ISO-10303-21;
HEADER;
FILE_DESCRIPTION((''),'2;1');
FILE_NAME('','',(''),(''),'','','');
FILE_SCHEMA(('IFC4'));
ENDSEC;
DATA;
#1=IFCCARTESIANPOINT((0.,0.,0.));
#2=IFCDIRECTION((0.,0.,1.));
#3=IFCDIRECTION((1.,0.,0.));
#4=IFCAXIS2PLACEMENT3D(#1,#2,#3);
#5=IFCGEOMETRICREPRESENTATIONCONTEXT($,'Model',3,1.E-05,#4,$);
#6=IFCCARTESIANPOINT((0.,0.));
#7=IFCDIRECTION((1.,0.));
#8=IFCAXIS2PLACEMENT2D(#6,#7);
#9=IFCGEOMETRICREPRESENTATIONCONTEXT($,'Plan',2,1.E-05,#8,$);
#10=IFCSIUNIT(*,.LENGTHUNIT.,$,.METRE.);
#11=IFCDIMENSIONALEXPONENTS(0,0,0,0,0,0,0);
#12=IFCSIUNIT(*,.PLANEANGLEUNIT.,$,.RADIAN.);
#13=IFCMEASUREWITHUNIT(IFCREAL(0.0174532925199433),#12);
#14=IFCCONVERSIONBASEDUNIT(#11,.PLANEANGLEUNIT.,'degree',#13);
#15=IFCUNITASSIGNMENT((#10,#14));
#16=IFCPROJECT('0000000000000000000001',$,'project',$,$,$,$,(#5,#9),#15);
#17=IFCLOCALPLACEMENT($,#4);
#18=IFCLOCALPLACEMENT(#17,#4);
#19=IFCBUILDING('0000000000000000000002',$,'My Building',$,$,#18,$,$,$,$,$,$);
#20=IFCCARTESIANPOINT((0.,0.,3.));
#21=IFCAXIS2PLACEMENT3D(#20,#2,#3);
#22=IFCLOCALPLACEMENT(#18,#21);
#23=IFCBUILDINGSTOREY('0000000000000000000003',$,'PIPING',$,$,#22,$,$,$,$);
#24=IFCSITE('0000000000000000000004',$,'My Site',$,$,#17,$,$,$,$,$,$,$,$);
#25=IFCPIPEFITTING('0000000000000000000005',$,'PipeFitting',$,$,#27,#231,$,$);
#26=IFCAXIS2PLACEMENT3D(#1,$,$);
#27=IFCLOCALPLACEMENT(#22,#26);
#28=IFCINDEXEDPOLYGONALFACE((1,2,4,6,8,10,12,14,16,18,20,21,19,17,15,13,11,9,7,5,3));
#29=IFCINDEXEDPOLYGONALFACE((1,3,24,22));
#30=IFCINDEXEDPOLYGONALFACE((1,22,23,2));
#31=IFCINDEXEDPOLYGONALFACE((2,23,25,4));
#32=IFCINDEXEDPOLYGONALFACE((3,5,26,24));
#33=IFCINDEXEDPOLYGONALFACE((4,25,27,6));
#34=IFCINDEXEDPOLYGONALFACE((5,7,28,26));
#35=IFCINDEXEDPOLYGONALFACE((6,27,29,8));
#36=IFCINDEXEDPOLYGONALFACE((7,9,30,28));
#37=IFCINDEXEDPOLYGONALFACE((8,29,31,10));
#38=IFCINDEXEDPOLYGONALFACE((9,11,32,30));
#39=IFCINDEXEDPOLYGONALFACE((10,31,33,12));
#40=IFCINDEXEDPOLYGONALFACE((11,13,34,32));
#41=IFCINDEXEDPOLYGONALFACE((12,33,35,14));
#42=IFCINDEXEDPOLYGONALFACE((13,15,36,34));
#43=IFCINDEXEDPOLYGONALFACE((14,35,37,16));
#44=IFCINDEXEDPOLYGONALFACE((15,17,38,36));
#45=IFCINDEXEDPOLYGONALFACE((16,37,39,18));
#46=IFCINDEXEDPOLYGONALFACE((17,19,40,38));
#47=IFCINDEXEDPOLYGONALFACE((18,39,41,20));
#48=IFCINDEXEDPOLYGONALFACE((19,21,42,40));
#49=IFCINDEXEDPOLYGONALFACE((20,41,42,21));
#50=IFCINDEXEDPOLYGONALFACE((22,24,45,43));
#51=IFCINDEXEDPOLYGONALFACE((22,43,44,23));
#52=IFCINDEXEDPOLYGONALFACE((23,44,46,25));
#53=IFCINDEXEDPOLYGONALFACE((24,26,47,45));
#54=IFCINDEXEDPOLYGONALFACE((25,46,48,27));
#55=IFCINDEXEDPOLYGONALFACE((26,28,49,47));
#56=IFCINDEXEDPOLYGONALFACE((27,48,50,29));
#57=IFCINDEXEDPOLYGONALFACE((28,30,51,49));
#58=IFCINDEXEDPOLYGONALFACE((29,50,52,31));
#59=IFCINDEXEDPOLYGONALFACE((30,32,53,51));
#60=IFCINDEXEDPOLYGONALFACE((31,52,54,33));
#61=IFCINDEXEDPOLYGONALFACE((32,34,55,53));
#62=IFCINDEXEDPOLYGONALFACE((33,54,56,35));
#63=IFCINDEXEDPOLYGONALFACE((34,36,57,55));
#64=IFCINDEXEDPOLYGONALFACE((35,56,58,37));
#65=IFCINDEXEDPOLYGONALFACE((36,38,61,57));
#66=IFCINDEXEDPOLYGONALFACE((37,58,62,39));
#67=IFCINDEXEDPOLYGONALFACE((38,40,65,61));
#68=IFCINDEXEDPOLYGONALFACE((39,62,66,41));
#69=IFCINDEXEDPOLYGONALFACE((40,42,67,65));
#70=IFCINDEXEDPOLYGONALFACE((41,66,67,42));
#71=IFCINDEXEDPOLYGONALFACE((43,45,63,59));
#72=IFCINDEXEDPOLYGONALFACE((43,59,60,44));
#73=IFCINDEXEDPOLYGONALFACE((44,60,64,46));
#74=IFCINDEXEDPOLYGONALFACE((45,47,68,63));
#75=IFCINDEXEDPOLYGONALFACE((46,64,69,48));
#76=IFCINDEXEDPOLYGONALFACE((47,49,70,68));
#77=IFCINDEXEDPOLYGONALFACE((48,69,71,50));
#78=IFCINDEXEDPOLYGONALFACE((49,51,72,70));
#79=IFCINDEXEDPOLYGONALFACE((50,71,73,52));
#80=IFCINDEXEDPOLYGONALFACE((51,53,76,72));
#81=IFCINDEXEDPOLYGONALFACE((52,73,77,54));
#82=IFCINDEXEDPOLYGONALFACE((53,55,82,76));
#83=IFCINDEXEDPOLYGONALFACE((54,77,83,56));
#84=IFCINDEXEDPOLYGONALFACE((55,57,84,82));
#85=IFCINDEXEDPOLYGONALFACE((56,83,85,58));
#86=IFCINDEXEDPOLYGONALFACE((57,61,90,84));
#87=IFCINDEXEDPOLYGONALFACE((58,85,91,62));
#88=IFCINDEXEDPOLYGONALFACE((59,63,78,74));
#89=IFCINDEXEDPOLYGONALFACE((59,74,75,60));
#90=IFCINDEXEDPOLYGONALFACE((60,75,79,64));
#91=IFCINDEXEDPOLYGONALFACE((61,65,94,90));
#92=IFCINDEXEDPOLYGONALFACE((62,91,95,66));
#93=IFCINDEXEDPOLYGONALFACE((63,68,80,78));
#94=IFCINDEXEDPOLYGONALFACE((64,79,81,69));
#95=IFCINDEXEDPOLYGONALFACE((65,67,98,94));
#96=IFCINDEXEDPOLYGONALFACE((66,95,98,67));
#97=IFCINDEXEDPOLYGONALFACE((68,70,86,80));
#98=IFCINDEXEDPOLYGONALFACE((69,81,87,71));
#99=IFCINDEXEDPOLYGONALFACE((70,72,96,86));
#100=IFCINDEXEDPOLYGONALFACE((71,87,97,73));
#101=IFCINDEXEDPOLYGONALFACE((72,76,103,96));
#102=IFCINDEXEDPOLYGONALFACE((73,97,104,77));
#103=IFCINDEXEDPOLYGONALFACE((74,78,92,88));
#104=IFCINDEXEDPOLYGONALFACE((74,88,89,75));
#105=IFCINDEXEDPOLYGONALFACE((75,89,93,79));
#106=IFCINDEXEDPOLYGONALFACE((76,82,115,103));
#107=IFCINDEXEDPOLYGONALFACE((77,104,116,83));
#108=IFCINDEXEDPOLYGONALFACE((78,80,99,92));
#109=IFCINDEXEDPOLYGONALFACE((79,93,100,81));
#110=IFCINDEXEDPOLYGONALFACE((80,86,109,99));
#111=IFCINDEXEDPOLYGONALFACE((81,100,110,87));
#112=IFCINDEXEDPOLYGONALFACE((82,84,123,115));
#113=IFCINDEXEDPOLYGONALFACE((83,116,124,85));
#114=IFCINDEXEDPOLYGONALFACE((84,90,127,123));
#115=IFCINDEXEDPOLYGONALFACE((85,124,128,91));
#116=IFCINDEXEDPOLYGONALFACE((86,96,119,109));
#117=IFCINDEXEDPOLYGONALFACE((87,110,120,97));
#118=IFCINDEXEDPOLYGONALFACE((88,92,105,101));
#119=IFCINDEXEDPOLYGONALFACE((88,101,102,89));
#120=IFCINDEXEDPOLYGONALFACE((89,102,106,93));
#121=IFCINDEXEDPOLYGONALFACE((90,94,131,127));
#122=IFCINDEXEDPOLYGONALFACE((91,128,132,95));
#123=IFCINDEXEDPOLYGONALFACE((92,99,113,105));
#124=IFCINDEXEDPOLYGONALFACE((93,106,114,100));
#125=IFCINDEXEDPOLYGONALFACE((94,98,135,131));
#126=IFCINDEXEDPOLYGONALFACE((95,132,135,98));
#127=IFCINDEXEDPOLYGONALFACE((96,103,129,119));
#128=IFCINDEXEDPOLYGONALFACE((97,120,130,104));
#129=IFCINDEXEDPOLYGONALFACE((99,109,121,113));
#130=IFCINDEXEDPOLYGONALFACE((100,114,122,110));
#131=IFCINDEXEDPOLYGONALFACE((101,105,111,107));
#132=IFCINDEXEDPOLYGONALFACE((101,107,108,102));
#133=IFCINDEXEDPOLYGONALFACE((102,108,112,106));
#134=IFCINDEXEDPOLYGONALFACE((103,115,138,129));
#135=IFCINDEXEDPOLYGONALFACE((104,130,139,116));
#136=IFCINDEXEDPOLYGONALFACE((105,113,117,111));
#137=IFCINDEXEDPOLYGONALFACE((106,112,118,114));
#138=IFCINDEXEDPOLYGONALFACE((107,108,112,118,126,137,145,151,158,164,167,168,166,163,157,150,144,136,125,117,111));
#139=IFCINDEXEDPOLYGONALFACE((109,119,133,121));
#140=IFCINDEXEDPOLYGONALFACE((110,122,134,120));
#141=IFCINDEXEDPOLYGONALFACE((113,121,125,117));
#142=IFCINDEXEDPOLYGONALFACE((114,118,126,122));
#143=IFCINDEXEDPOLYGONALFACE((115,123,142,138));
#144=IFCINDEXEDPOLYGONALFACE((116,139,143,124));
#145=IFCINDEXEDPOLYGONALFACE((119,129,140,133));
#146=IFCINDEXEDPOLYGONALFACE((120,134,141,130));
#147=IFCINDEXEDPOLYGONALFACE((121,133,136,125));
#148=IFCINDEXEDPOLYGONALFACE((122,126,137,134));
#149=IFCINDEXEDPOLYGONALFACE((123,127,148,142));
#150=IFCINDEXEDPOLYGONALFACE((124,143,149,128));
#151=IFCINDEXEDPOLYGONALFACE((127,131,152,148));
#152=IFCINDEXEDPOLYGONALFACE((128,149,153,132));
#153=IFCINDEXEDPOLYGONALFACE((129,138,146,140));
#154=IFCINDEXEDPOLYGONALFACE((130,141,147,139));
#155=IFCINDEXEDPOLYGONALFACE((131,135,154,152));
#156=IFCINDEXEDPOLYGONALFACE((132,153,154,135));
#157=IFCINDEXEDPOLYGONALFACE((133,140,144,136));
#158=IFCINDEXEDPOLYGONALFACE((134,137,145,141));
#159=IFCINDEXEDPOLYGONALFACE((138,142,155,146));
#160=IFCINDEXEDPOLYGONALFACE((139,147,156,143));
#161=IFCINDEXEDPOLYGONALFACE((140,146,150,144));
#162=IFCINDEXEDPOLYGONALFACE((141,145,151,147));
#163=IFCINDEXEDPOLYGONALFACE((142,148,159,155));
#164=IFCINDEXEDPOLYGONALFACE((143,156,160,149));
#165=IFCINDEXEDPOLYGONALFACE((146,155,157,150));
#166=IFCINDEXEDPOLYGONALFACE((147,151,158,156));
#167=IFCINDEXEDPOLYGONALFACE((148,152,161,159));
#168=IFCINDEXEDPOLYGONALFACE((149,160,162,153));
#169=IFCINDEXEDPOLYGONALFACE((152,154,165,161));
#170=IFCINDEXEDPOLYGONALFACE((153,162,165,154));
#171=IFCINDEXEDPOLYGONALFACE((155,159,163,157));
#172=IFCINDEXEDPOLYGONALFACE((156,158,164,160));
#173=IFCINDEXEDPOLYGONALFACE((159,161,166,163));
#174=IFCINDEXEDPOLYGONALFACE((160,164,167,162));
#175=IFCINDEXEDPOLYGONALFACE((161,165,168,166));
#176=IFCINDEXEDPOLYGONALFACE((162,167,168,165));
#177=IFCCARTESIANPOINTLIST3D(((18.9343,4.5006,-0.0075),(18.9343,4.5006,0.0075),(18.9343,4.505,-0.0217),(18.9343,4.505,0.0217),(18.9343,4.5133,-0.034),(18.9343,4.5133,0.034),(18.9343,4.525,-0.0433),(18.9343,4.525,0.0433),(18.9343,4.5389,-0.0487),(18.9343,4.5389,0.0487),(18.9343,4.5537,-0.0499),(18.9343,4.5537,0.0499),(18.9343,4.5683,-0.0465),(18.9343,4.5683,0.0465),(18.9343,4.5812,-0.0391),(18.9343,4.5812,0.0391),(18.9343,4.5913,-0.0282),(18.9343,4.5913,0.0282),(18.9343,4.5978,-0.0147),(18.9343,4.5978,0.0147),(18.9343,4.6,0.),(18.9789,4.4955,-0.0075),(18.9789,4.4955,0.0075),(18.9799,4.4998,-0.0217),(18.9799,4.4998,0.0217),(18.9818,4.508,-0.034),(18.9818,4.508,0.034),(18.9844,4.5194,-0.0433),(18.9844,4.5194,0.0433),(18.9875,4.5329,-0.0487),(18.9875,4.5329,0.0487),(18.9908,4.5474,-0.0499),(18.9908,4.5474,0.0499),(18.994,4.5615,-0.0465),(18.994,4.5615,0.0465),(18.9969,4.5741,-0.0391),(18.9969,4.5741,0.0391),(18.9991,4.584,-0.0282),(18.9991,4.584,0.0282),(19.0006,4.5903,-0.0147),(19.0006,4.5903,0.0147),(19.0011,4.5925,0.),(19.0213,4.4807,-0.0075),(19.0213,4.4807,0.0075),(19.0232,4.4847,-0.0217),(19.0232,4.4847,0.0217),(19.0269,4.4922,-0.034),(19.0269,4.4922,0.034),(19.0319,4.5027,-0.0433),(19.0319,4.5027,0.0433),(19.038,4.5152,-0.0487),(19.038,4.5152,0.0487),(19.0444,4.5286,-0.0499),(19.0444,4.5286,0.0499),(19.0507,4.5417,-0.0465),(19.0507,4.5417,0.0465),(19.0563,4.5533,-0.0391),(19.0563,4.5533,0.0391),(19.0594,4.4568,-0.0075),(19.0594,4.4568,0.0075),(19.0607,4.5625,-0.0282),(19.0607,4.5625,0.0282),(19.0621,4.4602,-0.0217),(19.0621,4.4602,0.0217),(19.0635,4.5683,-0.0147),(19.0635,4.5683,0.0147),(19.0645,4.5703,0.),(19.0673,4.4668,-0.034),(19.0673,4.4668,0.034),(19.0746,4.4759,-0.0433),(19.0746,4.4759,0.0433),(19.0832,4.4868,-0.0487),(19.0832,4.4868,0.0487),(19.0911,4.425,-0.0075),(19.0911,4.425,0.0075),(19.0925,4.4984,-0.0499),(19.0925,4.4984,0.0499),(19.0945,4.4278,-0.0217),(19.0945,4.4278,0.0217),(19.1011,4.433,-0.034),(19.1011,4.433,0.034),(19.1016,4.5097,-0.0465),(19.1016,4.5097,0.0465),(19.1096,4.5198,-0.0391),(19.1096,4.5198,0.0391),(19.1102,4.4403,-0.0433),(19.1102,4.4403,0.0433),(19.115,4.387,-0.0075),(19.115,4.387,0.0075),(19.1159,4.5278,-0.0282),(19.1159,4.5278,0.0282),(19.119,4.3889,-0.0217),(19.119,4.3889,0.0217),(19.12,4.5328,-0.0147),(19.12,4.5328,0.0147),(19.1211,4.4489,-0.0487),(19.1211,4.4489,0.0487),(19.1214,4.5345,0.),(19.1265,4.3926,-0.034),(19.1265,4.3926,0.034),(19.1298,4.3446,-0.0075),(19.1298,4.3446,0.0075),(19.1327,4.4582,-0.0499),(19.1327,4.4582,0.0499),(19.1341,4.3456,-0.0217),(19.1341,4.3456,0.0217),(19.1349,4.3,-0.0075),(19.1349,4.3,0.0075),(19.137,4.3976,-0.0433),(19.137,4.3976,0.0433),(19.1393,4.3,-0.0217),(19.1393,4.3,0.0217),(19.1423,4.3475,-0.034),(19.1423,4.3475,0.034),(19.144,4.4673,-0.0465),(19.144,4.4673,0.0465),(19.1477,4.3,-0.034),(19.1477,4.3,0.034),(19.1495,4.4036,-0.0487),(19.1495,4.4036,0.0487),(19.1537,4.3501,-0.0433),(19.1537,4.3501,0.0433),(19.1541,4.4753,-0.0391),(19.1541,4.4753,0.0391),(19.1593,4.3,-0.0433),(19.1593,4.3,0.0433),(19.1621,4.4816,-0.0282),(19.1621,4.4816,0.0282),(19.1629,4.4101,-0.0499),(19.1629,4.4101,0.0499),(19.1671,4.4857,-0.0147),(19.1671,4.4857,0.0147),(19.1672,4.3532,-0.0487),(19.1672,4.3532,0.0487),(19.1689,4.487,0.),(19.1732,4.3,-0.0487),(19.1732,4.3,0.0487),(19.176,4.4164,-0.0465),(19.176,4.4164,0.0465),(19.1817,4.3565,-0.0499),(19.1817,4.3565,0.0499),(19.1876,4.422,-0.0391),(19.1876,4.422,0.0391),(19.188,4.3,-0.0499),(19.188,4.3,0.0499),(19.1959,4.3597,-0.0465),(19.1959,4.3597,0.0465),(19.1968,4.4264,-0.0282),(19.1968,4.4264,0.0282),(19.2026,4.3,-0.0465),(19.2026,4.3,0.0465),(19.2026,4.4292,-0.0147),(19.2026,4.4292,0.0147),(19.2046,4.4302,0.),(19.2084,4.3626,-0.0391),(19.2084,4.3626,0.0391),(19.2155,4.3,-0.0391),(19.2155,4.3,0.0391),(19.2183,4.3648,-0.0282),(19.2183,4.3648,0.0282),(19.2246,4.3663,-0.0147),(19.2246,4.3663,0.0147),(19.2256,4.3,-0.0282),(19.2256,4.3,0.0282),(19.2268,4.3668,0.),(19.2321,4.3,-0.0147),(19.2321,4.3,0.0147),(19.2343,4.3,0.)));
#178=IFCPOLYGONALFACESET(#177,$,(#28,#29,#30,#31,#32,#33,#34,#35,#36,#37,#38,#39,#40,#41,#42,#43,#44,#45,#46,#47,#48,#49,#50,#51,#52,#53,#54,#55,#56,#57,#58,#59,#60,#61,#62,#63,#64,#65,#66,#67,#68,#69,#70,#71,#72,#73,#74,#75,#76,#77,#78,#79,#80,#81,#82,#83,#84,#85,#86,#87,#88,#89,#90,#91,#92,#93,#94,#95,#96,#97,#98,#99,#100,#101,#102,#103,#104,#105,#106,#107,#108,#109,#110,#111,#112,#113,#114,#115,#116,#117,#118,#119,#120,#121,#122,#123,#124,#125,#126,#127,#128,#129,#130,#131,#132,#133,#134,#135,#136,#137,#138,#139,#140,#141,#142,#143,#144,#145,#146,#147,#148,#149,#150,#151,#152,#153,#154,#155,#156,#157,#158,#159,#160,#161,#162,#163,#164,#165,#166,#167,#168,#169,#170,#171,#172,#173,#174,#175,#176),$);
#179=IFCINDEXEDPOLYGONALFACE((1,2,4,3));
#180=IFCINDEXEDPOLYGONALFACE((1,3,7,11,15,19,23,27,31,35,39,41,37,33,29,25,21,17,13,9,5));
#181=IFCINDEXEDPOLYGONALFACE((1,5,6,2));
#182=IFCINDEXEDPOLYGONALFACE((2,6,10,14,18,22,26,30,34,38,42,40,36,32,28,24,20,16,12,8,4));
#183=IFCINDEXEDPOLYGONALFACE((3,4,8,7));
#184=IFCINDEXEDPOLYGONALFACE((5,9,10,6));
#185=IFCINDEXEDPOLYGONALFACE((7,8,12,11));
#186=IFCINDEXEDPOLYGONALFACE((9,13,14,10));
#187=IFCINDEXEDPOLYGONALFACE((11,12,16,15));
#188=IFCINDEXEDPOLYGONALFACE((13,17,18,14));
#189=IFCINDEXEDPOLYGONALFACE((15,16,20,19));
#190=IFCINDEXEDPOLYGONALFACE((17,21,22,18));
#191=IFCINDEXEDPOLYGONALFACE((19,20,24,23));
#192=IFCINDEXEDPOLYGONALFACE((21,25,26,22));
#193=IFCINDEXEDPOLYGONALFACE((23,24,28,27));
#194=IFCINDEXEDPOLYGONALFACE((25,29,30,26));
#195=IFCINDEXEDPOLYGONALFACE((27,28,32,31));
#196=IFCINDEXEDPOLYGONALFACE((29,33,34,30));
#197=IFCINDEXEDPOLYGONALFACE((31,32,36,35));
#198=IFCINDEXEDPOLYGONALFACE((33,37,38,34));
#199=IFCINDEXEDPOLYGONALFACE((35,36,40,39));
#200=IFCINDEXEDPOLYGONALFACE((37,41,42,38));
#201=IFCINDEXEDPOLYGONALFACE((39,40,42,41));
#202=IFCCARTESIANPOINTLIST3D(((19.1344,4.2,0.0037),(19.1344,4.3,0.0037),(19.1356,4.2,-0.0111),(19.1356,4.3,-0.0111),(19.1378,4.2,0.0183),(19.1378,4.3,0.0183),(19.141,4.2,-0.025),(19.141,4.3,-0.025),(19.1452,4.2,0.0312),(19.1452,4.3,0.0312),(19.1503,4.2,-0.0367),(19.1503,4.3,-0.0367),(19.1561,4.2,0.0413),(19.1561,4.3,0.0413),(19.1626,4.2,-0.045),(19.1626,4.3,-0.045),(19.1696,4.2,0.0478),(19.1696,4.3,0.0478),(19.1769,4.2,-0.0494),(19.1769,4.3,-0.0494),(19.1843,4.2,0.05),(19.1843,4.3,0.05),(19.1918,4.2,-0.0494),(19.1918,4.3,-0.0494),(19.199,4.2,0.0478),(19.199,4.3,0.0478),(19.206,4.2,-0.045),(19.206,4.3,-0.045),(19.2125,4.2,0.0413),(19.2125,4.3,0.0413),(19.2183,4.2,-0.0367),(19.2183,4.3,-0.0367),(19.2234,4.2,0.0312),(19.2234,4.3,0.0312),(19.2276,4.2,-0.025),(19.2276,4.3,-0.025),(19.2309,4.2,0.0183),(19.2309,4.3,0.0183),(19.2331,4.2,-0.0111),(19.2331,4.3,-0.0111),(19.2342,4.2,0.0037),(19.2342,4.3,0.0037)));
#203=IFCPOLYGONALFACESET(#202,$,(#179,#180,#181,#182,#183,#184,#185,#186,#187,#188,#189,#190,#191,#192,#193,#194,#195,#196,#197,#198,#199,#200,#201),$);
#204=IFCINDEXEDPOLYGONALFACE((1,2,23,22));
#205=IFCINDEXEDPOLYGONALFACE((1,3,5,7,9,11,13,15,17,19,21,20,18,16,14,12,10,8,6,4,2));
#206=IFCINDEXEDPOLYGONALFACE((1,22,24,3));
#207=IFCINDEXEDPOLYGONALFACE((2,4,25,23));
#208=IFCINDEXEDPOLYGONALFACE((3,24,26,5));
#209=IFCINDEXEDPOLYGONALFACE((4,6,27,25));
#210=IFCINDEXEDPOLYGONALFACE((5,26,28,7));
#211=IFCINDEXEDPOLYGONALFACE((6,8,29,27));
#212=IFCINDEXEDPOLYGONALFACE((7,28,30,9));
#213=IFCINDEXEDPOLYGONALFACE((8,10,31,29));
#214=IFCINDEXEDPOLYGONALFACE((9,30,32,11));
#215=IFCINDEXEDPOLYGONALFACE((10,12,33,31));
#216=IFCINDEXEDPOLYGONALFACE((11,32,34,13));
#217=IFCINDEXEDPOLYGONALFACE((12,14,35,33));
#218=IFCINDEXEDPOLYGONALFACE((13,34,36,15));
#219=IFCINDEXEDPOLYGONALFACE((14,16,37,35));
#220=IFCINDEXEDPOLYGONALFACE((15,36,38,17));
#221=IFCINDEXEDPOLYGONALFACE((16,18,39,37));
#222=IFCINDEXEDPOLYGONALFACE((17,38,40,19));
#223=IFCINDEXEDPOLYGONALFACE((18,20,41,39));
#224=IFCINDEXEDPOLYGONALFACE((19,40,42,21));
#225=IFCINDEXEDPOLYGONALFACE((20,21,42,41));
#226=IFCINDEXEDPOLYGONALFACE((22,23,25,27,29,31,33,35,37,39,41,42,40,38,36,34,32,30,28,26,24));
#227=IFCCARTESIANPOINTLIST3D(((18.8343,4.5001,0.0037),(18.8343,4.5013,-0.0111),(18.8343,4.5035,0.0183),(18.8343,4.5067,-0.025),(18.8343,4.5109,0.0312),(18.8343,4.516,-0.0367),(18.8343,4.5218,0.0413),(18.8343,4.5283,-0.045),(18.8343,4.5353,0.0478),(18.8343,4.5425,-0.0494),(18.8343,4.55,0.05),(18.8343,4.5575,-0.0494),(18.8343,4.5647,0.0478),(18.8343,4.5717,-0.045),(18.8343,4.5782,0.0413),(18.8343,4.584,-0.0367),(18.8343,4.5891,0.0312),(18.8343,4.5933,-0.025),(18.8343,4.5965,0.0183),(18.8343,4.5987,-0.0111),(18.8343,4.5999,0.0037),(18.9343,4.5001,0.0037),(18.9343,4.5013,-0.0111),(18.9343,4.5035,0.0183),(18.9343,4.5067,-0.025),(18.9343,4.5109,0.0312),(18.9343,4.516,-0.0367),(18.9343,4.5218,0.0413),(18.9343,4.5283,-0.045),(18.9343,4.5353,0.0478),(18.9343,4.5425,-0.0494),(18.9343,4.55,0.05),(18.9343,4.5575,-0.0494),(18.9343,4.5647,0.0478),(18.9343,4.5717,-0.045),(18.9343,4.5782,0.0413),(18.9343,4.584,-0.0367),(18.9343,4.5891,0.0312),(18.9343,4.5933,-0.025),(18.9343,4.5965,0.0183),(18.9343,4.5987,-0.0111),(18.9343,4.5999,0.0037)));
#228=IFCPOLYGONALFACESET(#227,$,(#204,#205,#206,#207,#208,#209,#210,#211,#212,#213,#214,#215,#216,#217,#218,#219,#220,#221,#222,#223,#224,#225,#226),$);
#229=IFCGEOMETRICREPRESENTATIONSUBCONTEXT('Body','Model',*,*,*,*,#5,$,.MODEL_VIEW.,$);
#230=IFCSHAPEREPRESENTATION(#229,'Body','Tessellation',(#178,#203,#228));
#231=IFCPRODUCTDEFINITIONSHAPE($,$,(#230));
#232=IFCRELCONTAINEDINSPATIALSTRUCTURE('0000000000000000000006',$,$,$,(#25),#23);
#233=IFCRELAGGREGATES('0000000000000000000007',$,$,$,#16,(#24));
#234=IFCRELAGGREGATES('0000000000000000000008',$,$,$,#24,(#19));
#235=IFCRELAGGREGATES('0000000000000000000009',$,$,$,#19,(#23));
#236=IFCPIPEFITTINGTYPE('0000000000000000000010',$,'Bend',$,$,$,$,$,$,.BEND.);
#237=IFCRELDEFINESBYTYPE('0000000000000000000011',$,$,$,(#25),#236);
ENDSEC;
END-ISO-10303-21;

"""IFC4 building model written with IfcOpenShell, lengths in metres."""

from ifc_helpers import new_model, entity, si_unit, converted_unit, frame, origin_with_axes, origin_2d_with_axis, place, context, subcontext, project, spatial, line, indexed_curve, circle, outline, extrude, source, transform, mapped, type_object, type_shapes, element, save


model = new_model("IFC4")

# Units and contexts
model_context = context("Model", 3, precision=1e-05, world=origin_with_axes())
plan_context = context("Plan", 2, precision=1e-05, world=origin_2d_with_axis())
body_context = subcontext(model_context, "Body", "Model", "MODEL_VIEW")
ifc_project = project(units=[si_unit("LENGTHUNIT", "METRE"), converted_unit("PLANEANGLEUNIT", "degree", entity("IfcReal", 0.0174532925199433), si_unit("PLANEANGLEUNIT", "RADIAN"), dimensions=[0, 0, 0, 0, 0, 0, 0])], contexts=[model_context, plan_context])

# Site, building, storey
site_placement = place(None, origin_with_axes())
site = spatial("IfcSite", under=ifc_project, at=site_placement, Name="My Site")
building_placement = place(site_placement, origin_with_axes())
building = spatial("IfcBuilding", under=site, at=building_placement, Name="My Building")
storey_placement = place(building_placement, frame((0.0, 0.0, 3.0), z_axis=(0.0, 0.0, 1.0), x_axis=(1.0, 0.0, 0.0)))
storey = spatial("IfcBuildingStorey", under=building, at=storey_placement, Name="PIPING")

# Pipe fitting, opening
pipe_fitting_type = type_object("IfcPipeFittingType", Name="Bend", PredefinedType="BEND")
shared_shape = source(origin_with_axes(), body_context, "Body", "SolidModel", [
    entity("IfcSweptDiskSolid", entity("IfcIndexedPolyCurve", entity("IfcCartesianPointList3D", [[0.0, 0.0, 0.1], [0.0, -0.0732, 0.2768], [0.0, -0.25, 0.35]]), [entity("IfcArcIndex", [1, 2, 3])]), 0.05),
    extrude(circle(Radius=0.05), origin_with_axes(), (0.0, 0.0, 1.0), 0.1),
    extrude(circle(Radius=0.05), frame((0.0, -0.25, 0.35), z_axis=(0.0, -1.0, 0.0), x_axis=(1.0, 0.0, 0.0)), (0.0, 0.0, 1.0), 0.1),
])
type_shapes(pipe_fitting_type, [shared_shape])
pipe_fitting_1_placement = place(storey_placement, frame((19.1843, 4.2, 0.0), z_axis=(0.0, 1.0, 0.0), x_axis=(0.0, 0.0, 1.0)))
pipe_fitting_1 = element("IfcPipeFitting", 1, at=pipe_fitting_1_placement, inside=storey, type_object=pipe_fitting_type, Name="PipeFitting", context=body_context, shape_type="MappedRepresentation", body=[
    mapped(shared_shape, transform((0.0, 0.0, 0.0), x_axis=(1.0, 0.0, 0.0), y_axis=(0.0, 1.0, 0.0), z_axis=(0.0, 0.0, 1.0), scale=1.0)),
])
opening_1_placement = place(pipe_fitting_1_placement, frame((-3.0, -19.1843, -4.2), z_axis=(1.0, 0.0, 0.0), x_axis=(0.0, 1.0, 0.0)))
element("IfcOpeningElement", 2, at=opening_1_placement, cuts=pipe_fitting_1, PredefinedType="OPENING", context=body_context, shape_type="SweptSolid", body=[
    extrude(outline(indexed_curve([(0.0, 0.0), (0.5, 0.0), (0.5, 0.5), (0.0, 0.5)], segments=[line(1, 2, 3, 4, 1)])), origin_with_axes(), (0.0, 0.0, 1.0), 0.5),
])

save(model, "model.ifc")
